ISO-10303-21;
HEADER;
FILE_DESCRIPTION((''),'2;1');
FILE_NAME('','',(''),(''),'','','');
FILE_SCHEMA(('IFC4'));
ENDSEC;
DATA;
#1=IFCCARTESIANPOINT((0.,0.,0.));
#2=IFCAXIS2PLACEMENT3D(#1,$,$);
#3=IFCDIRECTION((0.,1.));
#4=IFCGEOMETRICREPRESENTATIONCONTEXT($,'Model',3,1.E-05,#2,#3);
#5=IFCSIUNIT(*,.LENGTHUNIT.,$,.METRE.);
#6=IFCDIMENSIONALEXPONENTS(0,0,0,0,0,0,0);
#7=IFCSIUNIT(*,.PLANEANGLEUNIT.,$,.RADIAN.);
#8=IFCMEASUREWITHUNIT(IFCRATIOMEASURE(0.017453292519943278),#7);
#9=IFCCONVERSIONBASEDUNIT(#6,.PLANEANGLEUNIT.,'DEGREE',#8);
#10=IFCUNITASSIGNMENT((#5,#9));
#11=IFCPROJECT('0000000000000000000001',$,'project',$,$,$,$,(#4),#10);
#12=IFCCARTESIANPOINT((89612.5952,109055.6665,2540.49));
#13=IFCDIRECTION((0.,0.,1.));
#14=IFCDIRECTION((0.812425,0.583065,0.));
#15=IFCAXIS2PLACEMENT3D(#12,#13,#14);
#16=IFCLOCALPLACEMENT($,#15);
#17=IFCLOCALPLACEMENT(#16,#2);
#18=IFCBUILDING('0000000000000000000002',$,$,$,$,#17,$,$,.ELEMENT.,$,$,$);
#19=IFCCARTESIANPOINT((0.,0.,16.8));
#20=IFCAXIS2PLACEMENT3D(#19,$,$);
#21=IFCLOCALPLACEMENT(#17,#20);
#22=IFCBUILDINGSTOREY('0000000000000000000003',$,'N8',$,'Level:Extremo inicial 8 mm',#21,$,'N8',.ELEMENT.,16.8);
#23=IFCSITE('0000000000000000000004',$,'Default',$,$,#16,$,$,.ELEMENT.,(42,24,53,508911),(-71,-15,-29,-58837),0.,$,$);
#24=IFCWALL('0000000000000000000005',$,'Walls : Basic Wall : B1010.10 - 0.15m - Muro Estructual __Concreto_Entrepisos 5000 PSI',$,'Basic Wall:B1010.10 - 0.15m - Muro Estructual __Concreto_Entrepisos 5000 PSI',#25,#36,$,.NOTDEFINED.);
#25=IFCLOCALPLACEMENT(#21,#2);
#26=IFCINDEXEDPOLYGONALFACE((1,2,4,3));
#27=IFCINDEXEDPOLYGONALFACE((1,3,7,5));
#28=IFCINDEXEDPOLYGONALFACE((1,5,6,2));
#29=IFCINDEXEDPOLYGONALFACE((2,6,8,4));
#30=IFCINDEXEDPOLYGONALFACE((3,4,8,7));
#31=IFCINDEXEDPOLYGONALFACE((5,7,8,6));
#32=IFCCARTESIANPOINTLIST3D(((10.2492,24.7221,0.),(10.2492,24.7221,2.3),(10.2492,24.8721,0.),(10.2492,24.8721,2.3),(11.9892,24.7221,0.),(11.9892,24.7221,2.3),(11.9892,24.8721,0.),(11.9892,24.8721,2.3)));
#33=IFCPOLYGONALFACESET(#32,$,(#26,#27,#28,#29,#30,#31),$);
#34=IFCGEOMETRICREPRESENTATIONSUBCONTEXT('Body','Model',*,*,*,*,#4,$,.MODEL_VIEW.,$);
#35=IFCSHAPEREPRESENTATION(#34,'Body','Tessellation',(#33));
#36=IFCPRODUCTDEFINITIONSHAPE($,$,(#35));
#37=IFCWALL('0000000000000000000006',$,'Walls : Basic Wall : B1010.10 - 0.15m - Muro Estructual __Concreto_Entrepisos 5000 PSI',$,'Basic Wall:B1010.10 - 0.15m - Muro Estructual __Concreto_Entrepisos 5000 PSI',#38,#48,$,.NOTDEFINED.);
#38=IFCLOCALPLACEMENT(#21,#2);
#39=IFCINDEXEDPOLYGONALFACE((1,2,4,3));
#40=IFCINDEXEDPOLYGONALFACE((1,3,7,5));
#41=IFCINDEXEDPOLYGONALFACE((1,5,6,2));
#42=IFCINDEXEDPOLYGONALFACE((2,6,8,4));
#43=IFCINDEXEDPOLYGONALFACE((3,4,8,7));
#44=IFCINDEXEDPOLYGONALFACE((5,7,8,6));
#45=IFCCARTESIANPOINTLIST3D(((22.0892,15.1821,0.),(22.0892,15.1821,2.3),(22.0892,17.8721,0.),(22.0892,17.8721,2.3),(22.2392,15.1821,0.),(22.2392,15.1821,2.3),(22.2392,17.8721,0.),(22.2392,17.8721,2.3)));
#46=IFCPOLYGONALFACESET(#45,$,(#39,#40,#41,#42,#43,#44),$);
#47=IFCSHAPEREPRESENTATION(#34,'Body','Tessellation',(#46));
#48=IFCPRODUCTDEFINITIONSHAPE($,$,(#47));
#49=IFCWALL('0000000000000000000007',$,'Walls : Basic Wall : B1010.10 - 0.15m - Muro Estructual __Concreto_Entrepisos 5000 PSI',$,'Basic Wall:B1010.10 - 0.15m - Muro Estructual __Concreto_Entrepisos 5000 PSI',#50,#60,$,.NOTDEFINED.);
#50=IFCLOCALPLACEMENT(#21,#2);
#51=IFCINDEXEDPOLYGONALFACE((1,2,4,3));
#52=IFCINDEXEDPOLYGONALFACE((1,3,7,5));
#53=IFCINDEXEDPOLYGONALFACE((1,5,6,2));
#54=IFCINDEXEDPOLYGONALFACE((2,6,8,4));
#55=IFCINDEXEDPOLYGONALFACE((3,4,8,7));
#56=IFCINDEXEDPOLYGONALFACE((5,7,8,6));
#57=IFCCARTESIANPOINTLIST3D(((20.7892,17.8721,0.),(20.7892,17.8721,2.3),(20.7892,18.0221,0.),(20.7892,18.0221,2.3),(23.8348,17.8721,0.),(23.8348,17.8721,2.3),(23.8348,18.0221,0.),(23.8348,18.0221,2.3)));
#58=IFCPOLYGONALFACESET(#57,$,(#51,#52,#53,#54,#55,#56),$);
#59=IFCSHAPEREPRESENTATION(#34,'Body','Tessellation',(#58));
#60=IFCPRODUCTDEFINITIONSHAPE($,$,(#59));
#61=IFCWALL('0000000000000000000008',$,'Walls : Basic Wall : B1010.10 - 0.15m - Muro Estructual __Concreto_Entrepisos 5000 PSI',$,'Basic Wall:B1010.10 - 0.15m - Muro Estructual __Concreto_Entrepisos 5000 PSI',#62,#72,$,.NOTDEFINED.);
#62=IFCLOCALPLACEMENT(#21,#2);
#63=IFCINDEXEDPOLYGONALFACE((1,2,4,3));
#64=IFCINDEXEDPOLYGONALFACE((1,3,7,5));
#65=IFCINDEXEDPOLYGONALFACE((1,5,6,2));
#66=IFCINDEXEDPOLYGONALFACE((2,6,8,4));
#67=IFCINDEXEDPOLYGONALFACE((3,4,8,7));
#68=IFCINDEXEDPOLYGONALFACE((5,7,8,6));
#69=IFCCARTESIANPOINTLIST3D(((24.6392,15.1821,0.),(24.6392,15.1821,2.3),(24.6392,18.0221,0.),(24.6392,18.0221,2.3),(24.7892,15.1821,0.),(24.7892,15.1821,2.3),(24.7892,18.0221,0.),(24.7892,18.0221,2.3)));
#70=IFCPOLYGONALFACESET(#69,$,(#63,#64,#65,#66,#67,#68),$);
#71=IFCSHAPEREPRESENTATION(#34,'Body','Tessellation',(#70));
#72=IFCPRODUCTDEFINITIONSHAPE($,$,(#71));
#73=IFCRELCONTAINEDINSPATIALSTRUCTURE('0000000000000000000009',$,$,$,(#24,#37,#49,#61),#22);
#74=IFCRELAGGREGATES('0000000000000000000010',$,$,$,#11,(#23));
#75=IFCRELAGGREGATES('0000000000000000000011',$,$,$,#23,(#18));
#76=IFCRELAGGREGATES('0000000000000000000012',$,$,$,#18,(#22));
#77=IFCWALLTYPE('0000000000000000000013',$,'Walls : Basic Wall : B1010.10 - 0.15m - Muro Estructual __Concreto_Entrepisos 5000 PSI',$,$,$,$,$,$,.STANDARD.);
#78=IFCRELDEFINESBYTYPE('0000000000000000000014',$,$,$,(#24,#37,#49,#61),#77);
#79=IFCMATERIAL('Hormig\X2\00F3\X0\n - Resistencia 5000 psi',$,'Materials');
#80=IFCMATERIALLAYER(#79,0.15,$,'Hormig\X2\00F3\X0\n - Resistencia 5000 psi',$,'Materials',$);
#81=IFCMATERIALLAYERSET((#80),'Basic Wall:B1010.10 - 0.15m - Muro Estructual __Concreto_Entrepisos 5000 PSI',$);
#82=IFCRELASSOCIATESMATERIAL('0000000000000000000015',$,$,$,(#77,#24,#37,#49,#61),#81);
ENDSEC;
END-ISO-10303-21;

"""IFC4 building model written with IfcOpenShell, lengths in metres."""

from ifc_helpers import new_model, entity, si_unit, converted_unit, direction, frame, frame_2d, origin, place, context, subcontext, project, spatial, rectangle, extrude, material, layer, layer_set, layer_usage, type_object, element, save


model = new_model("IFC4")

# Units and contexts
model_context = context("Model", 3, precision=1e-05, world=origin(), true_north=direction((0.0, 1.0)))
body_context = subcontext(model_context, "Body", "Model", "MODEL_VIEW")
ifc_project = project(units=[si_unit("LENGTHUNIT", "METRE"), converted_unit("PLANEANGLEUNIT", "DEGREE", entity("IfcRatioMeasure", 0.017453292519943278), si_unit("PLANEANGLEUNIT", "RADIAN"), dimensions=[0, 0, 0, 0, 0, 0, 0])], contexts=[model_context])

# Site, building, storey
site_placement = place(None, frame((89612.5952, 109055.6665, 2540.49), z_axis=(0.0, 0.0, 1.0), x_axis=(0.812425, 0.583065, 0.0)))
site = spatial("IfcSite", under=ifc_project, at=site_placement, Name="Default", CompositionType="ELEMENT", RefLatitude=(42, 24, 53, 508911), RefLongitude=(-71, -15, -29, -58837), RefElevation=0.0)
building_placement = place(site_placement, origin())
building = spatial("IfcBuilding", under=site, at=building_placement, CompositionType="ELEMENT")
storey_placement = place(building_placement, frame((0.0, 0.0, 16.8)))
storey = spatial("IfcBuildingStorey", under=building, at=storey_placement, Name="N8", ObjectType="Level:Extremo inicial 8 mm", LongName="N8", CompositionType="ELEMENT", Elevation=16.8)

# Walls
ifc_material = material(Name="Hormigón - Resistencia 5000 psi", Category="Materials")
ifc_layer_1 = layer(ifc_material, 0.15, Name="Hormigón - Resistencia 5000 psi", Category="Materials")
ifc_layer_set_1 = layer_set([ifc_layer_1], Name="Basic Wall:B1010.10 - 0.15m - Muro Estructual __Concreto_Entrepisos 5000 PSI")
wall_type_1 = type_object("IfcWallType", Name="Walls : Basic Wall : B1010.10 - 0.15m - Muro Estructual __Concreto_Entrepisos 5000 PSI", PredefinedType="STANDARD", material=ifc_layer_set_1)
ifc_layer_usage_1 = layer_usage(ifc_layer_set_1, "AXIS2", "POSITIVE", -0.075)
wall_1_placement = place(storey_placement, frame((11.9892, 24.7971, 0.0), z_axis=(0.0, 0.0, 1.0), x_axis=(-1.0, 0.0, 0.0)))
element("IfcWall", 1, at=wall_1_placement, inside=storey, type_object=wall_type_1, material=ifc_layer_usage_1, Name="Walls : Basic Wall : B1010.10 - 0.15m - Muro Estructual __Concreto_Entrepisos 5000 PSI", ObjectType="Basic Wall:B1010.10 - 0.15m - Muro Estructual __Concreto_Entrepisos 5000 PSI", PredefinedType="NOTDEFINED", context=body_context, shape_type="SweptSolid", body=[
    extrude(rectangle(XDim=1.74, YDim=0.15, at=frame_2d((0.87, 0.0), x_axis=(-1.0, 0.0))), origin(), (0.0, 0.0, 1.0), 2.3),
])
ifc_layer_usage_2 = layer_usage(ifc_layer_set_1, "AXIS2", "POSITIVE", -0.075)
wall_2_placement = place(storey_placement, frame((22.1642, 15.1821, 0.0), z_axis=(0.0, 0.0, 1.0), x_axis=(0.0, 1.0, 0.0)))
element("IfcWall", 2, at=wall_2_placement, inside=storey, type_object=wall_type_1, material=ifc_layer_usage_2, Name="Walls : Basic Wall : B1010.10 - 0.15m - Muro Estructual __Concreto_Entrepisos 5000 PSI", ObjectType="Basic Wall:B1010.10 - 0.15m - Muro Estructual __Concreto_Entrepisos 5000 PSI", PredefinedType="NOTDEFINED", context=body_context, shape_type="SweptSolid", body=[
    extrude(rectangle(XDim=2.69, YDim=0.15, at=frame_2d((1.345, 0.0), x_axis=(-1.0, 0.0))), origin(), (0.0, 0.0, 1.0), 2.3),
])
ifc_layer_usage_3 = layer_usage(ifc_layer_set_1, "AXIS2", "POSITIVE", -0.075)
wall_3_placement = place(storey_placement, frame((20.7892, 17.9471, 0.0)))
element("IfcWall", 3, at=wall_3_placement, inside=storey, type_object=wall_type_1, material=ifc_layer_usage_3, Name="Walls : Basic Wall : B1010.10 - 0.15m - Muro Estructual __Concreto_Entrepisos 5000 PSI", ObjectType="Basic Wall:B1010.10 - 0.15m - Muro Estructual __Concreto_Entrepisos 5000 PSI", PredefinedType="NOTDEFINED", context=body_context, shape_type="SweptSolid", body=[
    extrude(rectangle(XDim=3.0455, YDim=0.15, at=frame_2d((1.5228, 0.0), x_axis=(-1.0, 0.0))), origin(), (0.0, 0.0, 1.0), 2.3),
])
ifc_layer_usage_4 = layer_usage(ifc_layer_set_1, "AXIS2", "POSITIVE", -0.075)
wall_4_placement = place(storey_placement, frame((24.7142, 15.1821, 0.0), z_axis=(0.0, 0.0, 1.0), x_axis=(0.0, 1.0, 0.0)))
element("IfcWall", 4, at=wall_4_placement, inside=storey, type_object=wall_type_1, material=ifc_layer_usage_4, Name="Walls : Basic Wall : B1010.10 - 0.15m - Muro Estructual __Concreto_Entrepisos 5000 PSI", ObjectType="Basic Wall:B1010.10 - 0.15m - Muro Estructual __Concreto_Entrepisos 5000 PSI", PredefinedType="NOTDEFINED", context=body_context, shape_type="SweptSolid", body=[
    extrude(rectangle(XDim=2.84, YDim=0.15, at=frame_2d((1.42, 0.0), x_axis=(-1.0, 0.0))), origin(), (0.0, 0.0, 1.0), 2.3),
])

save(model, "model.ifc")
